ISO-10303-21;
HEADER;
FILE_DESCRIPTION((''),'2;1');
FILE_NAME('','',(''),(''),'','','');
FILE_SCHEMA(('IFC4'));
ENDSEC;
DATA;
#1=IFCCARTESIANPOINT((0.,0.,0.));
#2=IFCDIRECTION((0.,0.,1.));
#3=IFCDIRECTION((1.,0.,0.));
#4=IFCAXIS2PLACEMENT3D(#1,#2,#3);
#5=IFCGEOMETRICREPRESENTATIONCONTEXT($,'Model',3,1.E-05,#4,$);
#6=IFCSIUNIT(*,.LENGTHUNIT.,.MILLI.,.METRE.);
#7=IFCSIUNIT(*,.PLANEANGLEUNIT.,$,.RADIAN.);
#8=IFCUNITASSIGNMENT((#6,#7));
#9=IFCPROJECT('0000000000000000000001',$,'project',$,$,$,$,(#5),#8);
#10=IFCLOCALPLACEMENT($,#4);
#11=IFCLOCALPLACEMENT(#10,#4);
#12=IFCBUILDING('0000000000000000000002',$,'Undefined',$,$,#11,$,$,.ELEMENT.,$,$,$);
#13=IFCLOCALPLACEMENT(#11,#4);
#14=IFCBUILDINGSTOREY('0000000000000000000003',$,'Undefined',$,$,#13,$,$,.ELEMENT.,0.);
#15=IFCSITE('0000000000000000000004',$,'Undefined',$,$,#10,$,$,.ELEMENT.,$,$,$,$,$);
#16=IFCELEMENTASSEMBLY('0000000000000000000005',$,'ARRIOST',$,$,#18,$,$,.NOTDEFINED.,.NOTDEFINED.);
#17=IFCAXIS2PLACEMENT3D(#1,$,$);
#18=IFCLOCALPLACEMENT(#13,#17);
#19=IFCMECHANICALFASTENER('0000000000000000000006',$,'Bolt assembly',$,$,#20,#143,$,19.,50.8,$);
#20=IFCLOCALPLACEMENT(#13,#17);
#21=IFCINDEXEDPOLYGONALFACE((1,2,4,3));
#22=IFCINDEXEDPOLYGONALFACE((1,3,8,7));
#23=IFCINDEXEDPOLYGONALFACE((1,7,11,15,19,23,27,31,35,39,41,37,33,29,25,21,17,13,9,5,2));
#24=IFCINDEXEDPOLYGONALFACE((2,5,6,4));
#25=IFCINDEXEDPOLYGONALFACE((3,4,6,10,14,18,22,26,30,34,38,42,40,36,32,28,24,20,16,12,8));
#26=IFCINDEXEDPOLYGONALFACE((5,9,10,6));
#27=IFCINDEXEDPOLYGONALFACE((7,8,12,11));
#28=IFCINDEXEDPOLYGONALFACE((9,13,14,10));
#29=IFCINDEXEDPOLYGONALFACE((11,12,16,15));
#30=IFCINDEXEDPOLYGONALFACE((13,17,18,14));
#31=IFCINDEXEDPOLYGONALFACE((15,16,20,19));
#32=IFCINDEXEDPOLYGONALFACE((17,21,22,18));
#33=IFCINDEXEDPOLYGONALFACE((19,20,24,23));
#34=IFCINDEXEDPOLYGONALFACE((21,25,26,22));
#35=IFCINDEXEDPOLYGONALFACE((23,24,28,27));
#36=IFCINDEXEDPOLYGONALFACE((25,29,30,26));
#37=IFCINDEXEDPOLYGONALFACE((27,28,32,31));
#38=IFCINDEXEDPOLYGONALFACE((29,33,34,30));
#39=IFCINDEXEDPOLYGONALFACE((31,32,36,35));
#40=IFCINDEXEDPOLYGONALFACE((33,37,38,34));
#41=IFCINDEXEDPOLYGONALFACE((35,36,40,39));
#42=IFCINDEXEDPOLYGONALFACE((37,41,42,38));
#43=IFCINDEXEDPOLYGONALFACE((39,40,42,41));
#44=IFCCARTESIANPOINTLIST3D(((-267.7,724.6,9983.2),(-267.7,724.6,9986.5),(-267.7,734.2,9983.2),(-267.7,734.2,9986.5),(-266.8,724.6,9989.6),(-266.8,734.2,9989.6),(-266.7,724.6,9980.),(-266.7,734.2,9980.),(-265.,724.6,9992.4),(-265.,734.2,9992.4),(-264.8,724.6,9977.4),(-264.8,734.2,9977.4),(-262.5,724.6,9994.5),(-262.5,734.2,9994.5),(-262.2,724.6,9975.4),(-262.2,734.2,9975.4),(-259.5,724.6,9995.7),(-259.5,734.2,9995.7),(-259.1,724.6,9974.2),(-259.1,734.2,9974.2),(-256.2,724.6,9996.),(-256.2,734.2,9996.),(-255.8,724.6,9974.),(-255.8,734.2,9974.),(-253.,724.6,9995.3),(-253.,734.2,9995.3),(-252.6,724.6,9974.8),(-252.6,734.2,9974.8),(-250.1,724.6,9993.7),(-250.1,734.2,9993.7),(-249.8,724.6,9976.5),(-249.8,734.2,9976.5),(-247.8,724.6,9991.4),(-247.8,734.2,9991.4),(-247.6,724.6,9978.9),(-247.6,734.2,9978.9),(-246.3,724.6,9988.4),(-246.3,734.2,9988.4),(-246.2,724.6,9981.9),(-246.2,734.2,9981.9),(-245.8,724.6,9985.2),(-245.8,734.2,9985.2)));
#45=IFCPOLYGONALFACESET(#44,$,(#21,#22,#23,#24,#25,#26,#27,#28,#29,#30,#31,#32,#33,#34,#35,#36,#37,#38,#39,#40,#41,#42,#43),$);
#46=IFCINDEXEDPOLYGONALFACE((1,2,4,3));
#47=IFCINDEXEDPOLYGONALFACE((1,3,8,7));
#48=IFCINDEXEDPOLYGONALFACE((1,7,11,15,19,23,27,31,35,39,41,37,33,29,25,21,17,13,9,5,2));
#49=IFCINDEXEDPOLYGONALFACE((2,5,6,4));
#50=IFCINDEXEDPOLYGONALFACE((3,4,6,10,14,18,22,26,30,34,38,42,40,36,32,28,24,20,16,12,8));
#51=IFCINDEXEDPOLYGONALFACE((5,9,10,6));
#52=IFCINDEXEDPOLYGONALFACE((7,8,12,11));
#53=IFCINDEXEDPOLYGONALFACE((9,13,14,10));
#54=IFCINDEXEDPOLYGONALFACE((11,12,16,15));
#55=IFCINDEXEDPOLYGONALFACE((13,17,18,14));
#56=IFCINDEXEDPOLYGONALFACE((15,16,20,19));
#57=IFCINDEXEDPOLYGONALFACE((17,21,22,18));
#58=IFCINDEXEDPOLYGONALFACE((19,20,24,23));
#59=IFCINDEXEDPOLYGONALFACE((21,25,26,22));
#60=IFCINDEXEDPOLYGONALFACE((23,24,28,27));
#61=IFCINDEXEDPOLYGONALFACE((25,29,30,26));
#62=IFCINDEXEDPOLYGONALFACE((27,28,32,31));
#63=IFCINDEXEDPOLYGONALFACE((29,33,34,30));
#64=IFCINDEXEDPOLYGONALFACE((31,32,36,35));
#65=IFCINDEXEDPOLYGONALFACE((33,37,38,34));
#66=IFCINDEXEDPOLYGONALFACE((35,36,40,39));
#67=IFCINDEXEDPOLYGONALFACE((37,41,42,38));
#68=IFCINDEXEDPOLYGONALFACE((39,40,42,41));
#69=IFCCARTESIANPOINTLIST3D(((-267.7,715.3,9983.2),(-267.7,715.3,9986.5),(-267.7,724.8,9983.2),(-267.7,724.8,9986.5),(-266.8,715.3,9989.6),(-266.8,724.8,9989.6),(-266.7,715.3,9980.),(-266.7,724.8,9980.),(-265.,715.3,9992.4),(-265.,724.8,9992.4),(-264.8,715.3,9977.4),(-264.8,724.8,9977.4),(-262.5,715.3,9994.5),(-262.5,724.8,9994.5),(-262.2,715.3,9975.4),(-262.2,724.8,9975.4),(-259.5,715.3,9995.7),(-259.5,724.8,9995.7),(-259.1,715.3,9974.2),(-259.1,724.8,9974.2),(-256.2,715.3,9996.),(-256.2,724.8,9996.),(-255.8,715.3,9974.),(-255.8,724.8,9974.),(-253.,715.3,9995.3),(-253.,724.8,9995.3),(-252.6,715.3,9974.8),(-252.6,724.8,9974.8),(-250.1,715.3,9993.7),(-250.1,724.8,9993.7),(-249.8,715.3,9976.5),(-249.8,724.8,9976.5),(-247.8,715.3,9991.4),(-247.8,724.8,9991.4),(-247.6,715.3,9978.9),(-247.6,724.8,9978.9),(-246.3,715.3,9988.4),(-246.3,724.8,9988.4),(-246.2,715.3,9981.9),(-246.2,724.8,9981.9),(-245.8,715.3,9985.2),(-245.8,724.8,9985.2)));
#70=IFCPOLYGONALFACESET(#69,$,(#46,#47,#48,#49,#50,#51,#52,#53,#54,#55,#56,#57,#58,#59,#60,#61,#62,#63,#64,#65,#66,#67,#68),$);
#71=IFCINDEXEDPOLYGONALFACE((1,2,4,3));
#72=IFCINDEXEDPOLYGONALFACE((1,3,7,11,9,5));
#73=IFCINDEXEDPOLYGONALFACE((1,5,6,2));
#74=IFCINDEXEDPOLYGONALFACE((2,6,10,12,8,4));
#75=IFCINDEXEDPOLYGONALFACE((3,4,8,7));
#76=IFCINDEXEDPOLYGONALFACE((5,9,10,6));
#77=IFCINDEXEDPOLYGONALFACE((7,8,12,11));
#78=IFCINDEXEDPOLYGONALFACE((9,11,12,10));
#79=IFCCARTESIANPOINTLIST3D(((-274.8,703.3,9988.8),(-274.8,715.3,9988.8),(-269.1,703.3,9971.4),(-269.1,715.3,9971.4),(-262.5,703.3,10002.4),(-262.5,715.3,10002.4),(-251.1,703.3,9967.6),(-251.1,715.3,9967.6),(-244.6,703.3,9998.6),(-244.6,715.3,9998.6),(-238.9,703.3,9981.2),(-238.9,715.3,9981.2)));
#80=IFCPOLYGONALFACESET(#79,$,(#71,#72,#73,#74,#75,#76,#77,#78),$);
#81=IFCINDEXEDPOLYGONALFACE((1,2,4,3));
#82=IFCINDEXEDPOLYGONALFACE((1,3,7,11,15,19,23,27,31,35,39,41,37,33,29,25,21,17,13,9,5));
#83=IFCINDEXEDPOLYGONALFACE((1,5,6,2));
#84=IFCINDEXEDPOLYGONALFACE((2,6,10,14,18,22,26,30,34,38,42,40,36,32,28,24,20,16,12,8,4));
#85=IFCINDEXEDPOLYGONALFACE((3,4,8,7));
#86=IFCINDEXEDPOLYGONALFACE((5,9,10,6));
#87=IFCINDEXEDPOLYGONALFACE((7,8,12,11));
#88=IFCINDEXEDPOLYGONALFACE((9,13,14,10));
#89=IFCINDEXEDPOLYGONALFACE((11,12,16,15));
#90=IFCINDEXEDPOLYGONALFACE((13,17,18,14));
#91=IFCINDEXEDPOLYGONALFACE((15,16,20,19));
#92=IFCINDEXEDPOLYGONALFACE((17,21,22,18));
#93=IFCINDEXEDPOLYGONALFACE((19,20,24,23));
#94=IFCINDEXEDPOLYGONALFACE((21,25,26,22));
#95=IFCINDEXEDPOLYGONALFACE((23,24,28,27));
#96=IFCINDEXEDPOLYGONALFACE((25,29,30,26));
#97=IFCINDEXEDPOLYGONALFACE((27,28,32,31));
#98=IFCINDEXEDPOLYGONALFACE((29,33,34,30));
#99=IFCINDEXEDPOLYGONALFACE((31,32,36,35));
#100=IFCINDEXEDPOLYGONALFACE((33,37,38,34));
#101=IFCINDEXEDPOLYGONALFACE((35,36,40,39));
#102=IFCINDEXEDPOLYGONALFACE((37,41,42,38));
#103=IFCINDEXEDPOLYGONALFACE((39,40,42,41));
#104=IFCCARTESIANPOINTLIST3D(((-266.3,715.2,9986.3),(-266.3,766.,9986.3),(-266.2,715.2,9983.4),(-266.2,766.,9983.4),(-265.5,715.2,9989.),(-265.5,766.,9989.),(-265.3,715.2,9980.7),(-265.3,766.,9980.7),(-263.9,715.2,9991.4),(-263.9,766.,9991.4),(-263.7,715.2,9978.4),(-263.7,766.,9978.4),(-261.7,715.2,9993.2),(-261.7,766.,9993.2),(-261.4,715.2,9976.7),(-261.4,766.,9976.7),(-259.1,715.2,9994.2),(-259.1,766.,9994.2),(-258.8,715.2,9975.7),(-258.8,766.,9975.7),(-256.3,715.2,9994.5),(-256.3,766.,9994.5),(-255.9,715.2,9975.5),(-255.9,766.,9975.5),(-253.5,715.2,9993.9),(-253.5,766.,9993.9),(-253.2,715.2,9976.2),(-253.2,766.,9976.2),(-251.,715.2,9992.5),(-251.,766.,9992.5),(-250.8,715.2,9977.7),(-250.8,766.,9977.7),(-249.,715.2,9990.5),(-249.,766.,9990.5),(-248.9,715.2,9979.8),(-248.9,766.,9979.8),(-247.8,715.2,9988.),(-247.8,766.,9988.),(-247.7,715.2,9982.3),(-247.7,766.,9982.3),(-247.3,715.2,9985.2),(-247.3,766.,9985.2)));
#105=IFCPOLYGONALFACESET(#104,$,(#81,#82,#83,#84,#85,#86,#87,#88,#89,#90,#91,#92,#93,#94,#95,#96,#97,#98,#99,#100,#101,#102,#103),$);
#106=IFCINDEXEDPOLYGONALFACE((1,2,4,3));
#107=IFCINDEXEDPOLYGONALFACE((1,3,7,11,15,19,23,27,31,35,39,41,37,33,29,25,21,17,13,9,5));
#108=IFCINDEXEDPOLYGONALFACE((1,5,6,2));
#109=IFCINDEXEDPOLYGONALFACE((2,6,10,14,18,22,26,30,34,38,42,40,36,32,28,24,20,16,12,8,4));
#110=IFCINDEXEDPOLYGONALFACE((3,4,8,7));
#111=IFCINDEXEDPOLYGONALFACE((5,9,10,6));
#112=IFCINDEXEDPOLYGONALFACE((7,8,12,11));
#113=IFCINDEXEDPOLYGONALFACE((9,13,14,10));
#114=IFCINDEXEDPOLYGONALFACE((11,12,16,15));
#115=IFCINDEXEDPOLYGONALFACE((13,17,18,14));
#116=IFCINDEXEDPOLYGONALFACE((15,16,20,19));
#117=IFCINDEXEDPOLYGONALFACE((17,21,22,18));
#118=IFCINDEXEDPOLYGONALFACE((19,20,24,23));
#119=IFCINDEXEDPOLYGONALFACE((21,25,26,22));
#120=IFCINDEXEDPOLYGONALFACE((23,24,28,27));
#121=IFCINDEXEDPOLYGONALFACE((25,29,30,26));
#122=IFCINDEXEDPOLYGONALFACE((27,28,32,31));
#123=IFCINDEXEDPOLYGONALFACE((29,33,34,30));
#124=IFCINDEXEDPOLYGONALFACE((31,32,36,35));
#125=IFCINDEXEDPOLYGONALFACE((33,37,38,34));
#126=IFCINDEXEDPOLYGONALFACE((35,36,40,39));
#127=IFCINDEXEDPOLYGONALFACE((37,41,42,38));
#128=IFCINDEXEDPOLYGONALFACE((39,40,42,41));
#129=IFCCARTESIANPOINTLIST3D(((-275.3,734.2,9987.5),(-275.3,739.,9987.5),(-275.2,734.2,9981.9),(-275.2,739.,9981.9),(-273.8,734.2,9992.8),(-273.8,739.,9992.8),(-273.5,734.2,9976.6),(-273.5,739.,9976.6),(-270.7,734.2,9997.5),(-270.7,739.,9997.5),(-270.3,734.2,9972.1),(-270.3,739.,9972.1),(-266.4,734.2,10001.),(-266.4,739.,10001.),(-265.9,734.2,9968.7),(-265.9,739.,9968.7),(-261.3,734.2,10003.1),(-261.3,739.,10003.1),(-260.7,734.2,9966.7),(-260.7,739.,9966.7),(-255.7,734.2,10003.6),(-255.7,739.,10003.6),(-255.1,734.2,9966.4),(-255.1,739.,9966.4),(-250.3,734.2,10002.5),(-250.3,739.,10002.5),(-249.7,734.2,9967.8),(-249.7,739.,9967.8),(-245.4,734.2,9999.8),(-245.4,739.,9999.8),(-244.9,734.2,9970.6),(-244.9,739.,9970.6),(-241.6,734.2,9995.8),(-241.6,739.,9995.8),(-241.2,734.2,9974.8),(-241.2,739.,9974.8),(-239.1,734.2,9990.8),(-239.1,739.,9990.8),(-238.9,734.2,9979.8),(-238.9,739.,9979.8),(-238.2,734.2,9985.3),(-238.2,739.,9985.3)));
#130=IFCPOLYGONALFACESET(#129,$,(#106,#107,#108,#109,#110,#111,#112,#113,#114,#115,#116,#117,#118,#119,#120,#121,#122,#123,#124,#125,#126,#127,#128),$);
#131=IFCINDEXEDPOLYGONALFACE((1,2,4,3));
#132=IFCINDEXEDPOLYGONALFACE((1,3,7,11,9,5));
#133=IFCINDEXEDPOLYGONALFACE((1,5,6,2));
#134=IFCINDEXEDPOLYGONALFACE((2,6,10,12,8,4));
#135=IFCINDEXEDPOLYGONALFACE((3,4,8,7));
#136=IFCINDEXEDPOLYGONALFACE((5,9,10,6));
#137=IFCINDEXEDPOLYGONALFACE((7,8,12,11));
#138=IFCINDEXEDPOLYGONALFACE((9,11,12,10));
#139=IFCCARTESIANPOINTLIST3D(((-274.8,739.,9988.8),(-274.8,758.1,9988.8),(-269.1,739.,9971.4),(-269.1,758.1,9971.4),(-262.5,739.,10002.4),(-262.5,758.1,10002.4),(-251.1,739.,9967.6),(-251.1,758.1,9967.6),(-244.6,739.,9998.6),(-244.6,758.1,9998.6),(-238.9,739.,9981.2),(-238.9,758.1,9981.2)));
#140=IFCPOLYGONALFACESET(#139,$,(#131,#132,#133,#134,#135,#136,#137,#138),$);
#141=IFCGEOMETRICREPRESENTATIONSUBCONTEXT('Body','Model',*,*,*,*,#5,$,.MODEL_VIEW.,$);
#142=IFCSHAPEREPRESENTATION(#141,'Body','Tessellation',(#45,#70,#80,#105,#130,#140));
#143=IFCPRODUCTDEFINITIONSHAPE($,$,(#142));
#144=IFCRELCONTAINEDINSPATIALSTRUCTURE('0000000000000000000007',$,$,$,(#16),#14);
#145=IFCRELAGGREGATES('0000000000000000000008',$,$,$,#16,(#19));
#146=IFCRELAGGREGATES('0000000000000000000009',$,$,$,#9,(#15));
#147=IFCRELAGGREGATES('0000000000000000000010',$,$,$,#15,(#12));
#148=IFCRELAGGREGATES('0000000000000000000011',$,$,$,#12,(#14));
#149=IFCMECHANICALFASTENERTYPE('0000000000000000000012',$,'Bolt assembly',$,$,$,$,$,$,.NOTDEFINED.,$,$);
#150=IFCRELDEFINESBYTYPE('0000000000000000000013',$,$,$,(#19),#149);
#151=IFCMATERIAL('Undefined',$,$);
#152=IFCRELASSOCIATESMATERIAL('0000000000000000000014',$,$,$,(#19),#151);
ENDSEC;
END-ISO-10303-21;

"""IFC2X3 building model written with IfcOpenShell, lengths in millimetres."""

from ifc_helpers import new_model, si_unit, frame, origin_with_axes, origin_2d_with_axis, place, context, subcontext, project, spatial, polyline, circle, outline, extrude, source, transform, mapped, material, type_object, element, aggregate, save


model = new_model("IFC2X3")

# Units and contexts
model_context = context("Model", 3, precision=1e-05, world=origin_with_axes())
body_context = subcontext(model_context, "Body", "Model", "MODEL_VIEW")
ifc_project = project(units=[si_unit("LENGTHUNIT", "METRE", prefix="MILLI"), si_unit("PLANEANGLEUNIT", "RADIAN")], contexts=[model_context])

# Site, building, storey
site_placement = place(None, origin_with_axes())
site = spatial("IfcSite", under=ifc_project, at=site_placement, Name="Undefined", CompositionType="ELEMENT")
building_placement = place(site_placement, origin_with_axes())
building = spatial("IfcBuilding", under=site, at=building_placement, Name="Undefined", CompositionType="ELEMENT")
storey_placement = place(building_placement, origin_with_axes())
storey = spatial("IfcBuildingStorey", under=building, at=storey_placement, Name="Undefined", CompositionType="ELEMENT", Elevation=0.0)

# Element assembly
assembly_1_placement = place(storey_placement, origin_with_axes())
assembly_1 = element("IfcElementAssembly", 1, at=assembly_1_placement, inside=storey, Name="ARRIOST", AssemblyPlace="NOTDEFINED", PredefinedType="NOTDEFINED")

# Shared definitions
ifc_material_1 = material(Name="Undefined")
mechanical_fastener_type = type_object("IfcMechanicalFastenerType", Name="Bolt assembly")

# Mechanical fastener
shared_shape_1 = source(origin_with_axes(), body_context, "Body", "SweptSolid", [
    extrude(circle(Radius=11.0, at=origin_2d_with_axis()), frame((0.0, 4.6, 0.0), z_axis=(0.0, 1.0, 0.0), x_axis=(1.0, 0.0, 0.0)), (0.0, 0.0, 1.0), 9.6),
    extrude(circle(Radius=11.0, at=origin_2d_with_axis()), frame((0.0, -4.6, 0.0), z_axis=(0.0, 1.0, 0.0), x_axis=(1.0, 0.0, 0.0)), (0.0, 0.0, 1.0), 9.5),
    extrude(outline(polyline([(15.9, -9.2), (15.9, 9.2), (0.0, 18.3), (-15.9, 9.2), (-15.9, -9.2), (0.0, -18.3), (15.9, -9.2)])), frame((0.0, -16.7, 0.0), z_axis=(0.0, 1.0, 0.0), x_axis=(1.0, 0.0, 0.0)), (0.0, 0.0, 1.0), 11.9),
    extrude(circle(Radius=9.5, at=origin_2d_with_axis()), frame((0.0, -4.7, 0.0), z_axis=(0.0, 1.0, 0.0), x_axis=(1.0, 0.0, 0.0)), (0.0, 0.0, 1.0), 50.8),
    extrude(circle(Radius=18.7, at=origin_2d_with_axis()), frame((0.0, 14.2, 0.0), z_axis=(0.0, 1.0, 0.0), x_axis=(1.0, 0.0, 0.0)), (0.0, 0.0, 1.0), 4.8),
    extrude(outline(polyline([(15.9, -9.2), (15.9, 9.2), (0.0, 18.3), (-15.9, 9.2), (-15.9, -9.2), (0.0, -18.3), (15.9, -9.2)])), frame((0.0, 19.0, 0.0), z_axis=(0.0, 1.0, 0.0), x_axis=(1.0, 0.0, 0.0)), (0.0, 0.0, 1.0), 19.1),
])
mechanical_fastener_1_placement = place(assembly_1_placement, frame((-256.8, 720.0, 9985.0), z_axis=(-0.310822, 0.0, 0.950468), x_axis=(0.950468, 0.0, 0.310822)))
mechanical_fastener_1 = element("IfcMechanicalFastener", 2, at=mechanical_fastener_1_placement, type_object=mechanical_fastener_type, material=ifc_material_1, Name="Bolt assembly", NominalDiameter=19.0, NominalLength=50.8, context=body_context, shape_type="MappedRepresentation", body=[
    mapped(shared_shape_1, transform((0.0, 0.0, 0.0))),
])
aggregate(assembly_1, [mechanical_fastener_1])

save(model, "model.ifc")
